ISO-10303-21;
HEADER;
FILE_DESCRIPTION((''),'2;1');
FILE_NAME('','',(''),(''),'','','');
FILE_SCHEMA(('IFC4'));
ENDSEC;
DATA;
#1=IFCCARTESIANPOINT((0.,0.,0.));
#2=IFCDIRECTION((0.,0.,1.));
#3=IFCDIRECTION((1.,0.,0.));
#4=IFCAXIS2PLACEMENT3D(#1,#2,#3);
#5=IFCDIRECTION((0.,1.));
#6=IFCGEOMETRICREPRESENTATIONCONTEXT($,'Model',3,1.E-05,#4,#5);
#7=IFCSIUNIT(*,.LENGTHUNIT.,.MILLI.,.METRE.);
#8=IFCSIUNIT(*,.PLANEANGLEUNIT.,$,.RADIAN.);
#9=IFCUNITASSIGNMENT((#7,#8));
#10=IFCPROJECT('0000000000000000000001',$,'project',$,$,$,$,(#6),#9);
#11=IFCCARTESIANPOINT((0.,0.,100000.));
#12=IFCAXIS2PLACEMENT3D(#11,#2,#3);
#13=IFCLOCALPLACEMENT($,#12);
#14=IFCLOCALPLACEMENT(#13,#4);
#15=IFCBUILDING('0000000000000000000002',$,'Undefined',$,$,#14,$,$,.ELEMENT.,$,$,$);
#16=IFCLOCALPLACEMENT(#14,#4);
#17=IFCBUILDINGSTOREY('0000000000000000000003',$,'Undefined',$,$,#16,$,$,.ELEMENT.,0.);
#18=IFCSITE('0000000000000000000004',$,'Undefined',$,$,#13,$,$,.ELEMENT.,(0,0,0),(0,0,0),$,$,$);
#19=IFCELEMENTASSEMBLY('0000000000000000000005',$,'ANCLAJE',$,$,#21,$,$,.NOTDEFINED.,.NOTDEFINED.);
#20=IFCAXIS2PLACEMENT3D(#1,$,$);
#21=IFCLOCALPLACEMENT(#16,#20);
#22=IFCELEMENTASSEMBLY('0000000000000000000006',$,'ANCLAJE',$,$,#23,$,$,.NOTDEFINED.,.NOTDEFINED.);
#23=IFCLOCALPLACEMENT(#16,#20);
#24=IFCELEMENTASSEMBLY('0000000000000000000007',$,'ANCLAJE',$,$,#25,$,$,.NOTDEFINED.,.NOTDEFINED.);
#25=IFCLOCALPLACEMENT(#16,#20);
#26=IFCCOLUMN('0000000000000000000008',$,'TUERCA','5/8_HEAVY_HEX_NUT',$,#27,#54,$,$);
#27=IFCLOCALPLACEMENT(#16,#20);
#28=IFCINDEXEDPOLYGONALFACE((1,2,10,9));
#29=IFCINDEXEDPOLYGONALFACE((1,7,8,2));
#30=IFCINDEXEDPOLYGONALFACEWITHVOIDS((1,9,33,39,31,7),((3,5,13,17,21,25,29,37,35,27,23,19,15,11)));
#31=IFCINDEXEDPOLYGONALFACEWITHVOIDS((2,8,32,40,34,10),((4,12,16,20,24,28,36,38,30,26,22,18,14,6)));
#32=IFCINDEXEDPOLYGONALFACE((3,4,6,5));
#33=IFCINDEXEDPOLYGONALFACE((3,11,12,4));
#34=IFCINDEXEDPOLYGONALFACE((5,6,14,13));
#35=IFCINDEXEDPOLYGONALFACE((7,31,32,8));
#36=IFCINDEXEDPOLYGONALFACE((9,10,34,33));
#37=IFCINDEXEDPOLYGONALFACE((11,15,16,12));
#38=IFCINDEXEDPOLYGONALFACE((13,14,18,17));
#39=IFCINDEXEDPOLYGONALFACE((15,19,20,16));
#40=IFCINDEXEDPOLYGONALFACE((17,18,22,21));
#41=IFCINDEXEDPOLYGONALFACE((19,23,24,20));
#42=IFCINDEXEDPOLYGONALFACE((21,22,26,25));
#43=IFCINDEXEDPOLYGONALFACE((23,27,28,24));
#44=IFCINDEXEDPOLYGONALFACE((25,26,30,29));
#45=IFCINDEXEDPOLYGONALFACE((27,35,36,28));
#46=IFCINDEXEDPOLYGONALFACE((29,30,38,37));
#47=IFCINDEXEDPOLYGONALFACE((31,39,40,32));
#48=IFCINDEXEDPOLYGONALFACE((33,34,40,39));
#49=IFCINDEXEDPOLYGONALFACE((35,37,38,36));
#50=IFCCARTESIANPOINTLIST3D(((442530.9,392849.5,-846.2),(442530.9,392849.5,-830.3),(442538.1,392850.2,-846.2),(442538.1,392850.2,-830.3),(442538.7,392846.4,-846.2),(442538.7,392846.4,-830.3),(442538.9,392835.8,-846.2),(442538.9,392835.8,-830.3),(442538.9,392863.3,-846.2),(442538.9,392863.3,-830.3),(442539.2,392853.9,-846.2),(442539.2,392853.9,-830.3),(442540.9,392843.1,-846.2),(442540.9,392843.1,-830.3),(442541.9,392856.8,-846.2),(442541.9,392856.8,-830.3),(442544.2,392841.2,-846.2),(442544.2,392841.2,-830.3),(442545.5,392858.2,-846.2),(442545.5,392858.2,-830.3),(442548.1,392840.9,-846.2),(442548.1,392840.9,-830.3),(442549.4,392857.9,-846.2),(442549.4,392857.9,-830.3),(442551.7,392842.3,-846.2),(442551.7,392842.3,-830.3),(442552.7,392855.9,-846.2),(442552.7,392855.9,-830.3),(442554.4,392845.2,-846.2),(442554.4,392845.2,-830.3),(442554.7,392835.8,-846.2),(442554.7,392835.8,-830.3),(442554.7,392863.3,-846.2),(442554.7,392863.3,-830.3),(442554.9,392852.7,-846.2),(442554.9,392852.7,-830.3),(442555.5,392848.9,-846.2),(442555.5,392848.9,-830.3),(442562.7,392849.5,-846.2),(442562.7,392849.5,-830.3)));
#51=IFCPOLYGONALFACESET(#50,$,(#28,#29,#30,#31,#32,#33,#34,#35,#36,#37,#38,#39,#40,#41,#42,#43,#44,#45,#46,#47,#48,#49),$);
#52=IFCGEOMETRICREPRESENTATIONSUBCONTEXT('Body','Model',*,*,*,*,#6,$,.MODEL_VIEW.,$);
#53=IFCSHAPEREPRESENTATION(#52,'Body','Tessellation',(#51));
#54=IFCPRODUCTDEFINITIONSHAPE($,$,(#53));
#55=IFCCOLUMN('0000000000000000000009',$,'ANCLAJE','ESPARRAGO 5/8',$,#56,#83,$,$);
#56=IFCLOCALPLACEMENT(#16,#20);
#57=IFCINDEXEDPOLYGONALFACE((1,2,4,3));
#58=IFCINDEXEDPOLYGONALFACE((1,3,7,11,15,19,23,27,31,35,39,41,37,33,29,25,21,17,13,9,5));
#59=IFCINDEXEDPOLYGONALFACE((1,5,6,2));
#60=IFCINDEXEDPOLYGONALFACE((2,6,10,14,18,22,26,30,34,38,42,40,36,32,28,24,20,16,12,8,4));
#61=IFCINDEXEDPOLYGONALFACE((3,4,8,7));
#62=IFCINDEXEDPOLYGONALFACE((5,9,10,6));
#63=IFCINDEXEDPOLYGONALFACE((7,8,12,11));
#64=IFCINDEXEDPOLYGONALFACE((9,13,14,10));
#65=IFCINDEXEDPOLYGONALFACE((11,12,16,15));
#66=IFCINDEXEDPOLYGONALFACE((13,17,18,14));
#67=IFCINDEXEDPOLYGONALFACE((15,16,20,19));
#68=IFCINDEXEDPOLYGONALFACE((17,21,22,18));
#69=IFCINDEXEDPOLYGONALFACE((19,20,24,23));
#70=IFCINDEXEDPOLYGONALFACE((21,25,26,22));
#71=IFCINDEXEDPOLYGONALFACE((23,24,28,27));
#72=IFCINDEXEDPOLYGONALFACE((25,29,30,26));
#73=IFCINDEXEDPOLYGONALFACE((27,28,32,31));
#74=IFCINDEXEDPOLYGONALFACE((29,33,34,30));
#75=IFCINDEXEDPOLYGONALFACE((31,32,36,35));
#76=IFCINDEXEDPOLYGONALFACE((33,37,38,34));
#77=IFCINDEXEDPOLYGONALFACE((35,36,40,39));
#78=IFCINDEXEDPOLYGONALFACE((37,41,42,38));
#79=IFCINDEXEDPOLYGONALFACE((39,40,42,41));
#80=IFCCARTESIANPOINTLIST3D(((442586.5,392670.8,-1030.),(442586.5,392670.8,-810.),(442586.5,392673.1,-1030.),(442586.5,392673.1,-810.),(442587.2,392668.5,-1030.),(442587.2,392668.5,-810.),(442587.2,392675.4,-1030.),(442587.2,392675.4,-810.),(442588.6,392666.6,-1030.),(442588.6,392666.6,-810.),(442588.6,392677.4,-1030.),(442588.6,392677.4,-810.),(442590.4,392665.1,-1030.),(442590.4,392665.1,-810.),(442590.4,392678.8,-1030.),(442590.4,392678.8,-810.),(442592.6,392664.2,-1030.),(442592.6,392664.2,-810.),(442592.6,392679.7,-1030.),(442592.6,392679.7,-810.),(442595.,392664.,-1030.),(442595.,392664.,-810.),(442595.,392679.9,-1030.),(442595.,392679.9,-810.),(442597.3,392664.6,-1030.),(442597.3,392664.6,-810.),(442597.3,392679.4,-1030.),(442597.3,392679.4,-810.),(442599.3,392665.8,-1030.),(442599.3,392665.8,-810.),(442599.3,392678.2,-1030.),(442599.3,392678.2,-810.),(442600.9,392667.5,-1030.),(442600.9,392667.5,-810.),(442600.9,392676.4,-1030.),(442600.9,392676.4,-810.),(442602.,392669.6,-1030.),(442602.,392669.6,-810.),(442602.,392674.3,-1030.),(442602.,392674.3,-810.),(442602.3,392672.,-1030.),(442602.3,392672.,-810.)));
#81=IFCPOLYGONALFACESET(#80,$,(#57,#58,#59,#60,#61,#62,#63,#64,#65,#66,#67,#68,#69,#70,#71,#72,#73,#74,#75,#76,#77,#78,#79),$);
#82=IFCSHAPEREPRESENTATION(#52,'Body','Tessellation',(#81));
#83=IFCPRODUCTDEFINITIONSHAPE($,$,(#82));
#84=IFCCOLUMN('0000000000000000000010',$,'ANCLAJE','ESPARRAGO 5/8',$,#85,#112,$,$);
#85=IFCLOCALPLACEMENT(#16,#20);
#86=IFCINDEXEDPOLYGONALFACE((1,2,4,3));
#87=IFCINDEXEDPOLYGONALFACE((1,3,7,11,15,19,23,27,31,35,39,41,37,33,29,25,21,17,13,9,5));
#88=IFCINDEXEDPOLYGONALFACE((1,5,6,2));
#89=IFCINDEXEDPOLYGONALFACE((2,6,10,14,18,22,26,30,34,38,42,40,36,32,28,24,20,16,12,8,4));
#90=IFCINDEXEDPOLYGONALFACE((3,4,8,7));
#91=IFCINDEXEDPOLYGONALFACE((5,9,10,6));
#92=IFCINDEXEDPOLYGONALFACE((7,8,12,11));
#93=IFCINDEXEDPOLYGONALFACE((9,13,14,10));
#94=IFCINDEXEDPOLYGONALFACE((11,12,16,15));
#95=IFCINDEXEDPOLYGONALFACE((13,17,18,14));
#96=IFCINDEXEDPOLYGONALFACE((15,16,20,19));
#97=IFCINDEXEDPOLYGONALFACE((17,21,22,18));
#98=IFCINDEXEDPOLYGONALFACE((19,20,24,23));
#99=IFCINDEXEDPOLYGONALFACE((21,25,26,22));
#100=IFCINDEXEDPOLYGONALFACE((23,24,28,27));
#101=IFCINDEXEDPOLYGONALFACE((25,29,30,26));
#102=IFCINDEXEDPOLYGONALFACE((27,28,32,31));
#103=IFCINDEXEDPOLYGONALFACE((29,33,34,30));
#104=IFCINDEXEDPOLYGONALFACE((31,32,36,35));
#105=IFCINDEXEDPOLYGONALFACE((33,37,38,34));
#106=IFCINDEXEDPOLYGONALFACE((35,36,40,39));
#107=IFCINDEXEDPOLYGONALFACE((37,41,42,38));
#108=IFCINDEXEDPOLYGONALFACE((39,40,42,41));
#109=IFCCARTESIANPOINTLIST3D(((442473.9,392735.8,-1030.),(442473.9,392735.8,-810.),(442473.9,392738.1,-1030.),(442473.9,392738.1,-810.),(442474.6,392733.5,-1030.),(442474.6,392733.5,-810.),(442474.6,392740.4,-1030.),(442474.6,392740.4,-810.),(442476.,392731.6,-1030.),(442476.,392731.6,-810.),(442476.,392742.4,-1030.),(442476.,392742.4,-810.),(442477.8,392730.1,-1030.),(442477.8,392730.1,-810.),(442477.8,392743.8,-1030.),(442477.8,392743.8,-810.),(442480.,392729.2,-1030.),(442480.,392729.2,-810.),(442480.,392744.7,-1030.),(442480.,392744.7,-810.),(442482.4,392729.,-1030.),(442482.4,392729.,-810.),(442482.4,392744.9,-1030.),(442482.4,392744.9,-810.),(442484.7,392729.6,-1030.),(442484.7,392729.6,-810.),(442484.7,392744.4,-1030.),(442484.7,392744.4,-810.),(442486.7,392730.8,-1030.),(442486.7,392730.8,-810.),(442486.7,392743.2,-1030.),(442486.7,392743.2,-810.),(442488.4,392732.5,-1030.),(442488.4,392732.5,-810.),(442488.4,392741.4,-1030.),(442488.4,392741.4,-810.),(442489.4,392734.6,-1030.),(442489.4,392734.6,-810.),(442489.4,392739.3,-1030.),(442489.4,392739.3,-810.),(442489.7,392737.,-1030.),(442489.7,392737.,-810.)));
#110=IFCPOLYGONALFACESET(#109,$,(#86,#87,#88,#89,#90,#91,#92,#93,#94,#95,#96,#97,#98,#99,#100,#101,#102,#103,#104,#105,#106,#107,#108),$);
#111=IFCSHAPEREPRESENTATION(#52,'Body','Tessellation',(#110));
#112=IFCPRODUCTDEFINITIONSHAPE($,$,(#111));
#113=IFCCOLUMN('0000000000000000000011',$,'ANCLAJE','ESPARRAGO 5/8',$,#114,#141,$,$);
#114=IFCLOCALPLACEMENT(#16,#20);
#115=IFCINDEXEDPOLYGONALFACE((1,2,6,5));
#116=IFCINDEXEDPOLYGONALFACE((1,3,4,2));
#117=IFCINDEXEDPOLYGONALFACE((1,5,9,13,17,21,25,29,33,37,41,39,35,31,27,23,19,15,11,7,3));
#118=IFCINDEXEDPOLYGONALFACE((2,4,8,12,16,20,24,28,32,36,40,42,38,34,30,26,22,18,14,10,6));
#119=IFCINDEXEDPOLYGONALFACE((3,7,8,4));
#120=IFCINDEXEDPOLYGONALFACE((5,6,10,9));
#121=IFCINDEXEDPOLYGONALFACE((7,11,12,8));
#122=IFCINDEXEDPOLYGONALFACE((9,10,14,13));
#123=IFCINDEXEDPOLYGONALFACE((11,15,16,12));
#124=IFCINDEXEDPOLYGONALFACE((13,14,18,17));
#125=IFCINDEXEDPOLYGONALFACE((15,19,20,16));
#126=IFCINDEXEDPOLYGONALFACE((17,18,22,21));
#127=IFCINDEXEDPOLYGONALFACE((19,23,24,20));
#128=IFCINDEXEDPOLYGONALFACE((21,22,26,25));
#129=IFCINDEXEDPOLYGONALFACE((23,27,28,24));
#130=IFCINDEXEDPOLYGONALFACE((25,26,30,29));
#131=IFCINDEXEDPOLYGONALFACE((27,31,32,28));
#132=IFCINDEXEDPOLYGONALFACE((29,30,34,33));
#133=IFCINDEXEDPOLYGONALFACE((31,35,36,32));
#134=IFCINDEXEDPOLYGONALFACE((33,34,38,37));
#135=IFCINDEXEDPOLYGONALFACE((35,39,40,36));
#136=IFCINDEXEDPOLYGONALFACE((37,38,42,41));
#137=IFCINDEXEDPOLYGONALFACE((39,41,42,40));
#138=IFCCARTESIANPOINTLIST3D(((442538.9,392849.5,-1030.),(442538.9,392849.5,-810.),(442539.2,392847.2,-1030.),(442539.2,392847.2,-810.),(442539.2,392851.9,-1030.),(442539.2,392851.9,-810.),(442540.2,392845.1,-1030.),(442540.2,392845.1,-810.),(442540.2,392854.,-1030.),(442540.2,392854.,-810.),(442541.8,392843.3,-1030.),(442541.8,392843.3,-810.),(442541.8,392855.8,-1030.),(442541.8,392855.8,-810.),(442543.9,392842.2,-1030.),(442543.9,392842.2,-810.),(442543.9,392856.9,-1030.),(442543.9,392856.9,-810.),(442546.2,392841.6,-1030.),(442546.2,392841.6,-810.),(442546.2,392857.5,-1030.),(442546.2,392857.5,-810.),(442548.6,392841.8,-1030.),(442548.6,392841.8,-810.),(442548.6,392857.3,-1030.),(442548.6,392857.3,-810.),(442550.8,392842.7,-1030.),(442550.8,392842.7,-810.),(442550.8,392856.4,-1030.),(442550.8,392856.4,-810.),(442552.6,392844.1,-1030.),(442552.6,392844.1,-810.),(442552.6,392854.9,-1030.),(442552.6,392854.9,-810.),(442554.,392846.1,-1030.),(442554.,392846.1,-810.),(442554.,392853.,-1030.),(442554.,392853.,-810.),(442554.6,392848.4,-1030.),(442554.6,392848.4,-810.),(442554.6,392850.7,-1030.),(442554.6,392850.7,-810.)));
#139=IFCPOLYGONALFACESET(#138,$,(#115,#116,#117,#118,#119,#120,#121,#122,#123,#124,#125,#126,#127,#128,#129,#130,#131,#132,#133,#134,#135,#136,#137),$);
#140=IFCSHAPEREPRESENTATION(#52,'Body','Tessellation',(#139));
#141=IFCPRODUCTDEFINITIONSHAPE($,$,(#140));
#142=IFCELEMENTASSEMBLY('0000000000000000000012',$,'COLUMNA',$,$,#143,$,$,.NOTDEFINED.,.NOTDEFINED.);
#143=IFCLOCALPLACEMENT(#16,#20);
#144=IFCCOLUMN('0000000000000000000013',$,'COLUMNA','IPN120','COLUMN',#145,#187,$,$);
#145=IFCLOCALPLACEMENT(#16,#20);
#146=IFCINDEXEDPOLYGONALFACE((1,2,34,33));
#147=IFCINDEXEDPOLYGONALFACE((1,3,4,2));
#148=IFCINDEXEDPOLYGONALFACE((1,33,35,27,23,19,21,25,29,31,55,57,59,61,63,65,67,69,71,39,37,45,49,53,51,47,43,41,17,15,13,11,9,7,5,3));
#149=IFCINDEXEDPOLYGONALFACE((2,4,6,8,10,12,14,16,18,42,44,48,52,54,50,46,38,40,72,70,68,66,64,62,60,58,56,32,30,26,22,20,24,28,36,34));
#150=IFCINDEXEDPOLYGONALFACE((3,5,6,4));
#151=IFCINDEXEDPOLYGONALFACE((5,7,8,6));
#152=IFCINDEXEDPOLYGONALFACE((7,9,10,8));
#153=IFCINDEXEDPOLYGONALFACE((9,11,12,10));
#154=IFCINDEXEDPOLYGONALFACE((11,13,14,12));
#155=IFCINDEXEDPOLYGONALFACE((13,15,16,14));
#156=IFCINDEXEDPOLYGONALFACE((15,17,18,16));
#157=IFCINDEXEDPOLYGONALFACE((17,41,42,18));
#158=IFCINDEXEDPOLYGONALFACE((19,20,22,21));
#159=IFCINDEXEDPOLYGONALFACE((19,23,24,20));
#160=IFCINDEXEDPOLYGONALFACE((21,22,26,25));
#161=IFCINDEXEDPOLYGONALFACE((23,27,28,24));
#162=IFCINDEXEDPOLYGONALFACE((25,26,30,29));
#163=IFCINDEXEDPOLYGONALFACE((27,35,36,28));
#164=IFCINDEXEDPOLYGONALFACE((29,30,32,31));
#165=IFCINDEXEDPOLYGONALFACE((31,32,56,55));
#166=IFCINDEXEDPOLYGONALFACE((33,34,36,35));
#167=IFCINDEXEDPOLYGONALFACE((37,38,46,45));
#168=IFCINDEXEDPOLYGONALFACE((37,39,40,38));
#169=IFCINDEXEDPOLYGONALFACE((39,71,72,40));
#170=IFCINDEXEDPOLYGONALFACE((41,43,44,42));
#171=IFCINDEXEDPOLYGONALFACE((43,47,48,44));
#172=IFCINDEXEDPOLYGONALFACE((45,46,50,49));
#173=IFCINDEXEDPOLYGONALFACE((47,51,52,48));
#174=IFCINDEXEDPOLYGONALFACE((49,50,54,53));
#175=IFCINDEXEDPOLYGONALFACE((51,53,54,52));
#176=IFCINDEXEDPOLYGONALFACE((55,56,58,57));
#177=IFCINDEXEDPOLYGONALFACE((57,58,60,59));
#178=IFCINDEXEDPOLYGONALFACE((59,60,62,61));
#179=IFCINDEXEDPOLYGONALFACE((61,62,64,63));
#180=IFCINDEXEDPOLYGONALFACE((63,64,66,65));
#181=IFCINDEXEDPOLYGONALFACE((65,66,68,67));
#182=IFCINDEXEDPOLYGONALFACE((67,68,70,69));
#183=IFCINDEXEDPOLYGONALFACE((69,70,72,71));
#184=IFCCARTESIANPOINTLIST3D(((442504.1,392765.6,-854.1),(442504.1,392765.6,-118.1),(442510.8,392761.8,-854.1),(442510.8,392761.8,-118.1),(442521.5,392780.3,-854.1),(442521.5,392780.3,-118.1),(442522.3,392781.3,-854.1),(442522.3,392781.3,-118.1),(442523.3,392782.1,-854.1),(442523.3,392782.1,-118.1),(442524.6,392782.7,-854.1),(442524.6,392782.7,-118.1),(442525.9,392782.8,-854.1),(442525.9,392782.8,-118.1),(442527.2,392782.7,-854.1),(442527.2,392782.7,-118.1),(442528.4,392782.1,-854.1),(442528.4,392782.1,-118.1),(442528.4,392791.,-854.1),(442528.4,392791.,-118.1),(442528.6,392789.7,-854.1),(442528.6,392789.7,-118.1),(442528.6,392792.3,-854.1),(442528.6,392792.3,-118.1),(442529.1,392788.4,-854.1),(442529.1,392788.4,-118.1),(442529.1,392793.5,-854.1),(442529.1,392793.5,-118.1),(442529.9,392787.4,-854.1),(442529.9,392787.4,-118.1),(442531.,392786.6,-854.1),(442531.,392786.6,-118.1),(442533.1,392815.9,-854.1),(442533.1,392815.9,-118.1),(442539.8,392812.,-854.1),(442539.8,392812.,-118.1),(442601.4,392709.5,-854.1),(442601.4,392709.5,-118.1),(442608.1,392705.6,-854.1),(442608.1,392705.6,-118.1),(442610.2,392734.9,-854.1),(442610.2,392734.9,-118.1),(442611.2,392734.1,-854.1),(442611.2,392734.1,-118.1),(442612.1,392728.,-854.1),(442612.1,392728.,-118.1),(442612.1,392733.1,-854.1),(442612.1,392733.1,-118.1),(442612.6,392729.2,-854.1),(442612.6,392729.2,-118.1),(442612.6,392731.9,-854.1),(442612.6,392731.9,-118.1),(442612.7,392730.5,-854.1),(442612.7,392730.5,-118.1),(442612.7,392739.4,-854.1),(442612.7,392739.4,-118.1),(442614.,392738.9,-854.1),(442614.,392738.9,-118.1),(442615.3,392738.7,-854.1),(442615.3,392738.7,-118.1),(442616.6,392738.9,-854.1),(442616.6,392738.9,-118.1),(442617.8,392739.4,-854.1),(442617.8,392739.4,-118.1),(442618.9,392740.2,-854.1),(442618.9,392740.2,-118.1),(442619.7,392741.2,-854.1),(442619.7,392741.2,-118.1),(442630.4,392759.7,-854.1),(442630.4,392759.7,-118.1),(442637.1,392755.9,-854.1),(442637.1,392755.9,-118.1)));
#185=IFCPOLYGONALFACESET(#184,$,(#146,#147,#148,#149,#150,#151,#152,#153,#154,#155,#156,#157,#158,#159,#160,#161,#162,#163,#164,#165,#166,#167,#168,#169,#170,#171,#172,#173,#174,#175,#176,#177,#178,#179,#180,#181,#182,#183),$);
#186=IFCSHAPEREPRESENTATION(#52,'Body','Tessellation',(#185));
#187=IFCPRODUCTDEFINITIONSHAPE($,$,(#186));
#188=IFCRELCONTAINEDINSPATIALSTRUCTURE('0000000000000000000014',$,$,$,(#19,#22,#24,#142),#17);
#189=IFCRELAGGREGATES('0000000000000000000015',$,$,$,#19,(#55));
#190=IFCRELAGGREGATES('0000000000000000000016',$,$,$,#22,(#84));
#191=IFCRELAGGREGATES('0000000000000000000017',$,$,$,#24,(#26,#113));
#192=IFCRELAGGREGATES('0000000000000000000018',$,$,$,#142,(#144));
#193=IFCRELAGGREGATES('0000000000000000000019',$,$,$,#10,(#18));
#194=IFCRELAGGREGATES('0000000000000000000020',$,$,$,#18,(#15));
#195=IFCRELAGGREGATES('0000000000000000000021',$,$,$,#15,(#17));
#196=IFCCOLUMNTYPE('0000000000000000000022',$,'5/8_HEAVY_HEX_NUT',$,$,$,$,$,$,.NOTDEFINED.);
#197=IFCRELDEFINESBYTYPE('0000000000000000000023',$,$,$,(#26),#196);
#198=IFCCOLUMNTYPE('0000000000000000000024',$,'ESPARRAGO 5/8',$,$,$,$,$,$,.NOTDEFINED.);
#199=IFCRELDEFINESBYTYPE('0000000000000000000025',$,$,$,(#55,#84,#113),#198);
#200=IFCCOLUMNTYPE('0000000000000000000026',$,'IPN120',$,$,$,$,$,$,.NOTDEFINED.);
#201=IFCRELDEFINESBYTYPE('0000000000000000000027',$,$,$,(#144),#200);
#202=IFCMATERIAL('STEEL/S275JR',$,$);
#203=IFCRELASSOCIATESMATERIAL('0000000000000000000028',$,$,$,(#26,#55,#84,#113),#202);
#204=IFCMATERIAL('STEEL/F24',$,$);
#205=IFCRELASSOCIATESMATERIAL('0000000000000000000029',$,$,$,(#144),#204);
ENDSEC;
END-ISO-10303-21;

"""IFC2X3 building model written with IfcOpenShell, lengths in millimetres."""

from ifc_helpers import new_model, si_unit, direction, frame, origin_with_axes, origin_2d_with_axis, place, context, subcontext, project, spatial, polyline, circle, i_section, outline, extrude, clip, halfspace, material, type_object, element, aggregate, save


model = new_model("IFC2X3")

# Units and contexts
model_context = context("Model", 3, precision=1e-05, world=origin_with_axes(), true_north=direction((0.0, 1.0)))
body_context = subcontext(model_context, "Body", "Model", "MODEL_VIEW")
ifc_project = project(units=[si_unit("LENGTHUNIT", "METRE", prefix="MILLI"), si_unit("PLANEANGLEUNIT", "RADIAN")], contexts=[model_context])

# Site, building, storey
site_placement = place(None, frame((0.0, 0.0, 100000.0), z_axis=(0.0, 0.0, 1.0), x_axis=(1.0, 0.0, 0.0)))
site = spatial("IfcSite", under=ifc_project, at=site_placement, Name="Undefined", CompositionType="ELEMENT", RefLatitude=(0, 0, 0), RefLongitude=(0, 0, 0))
building_placement = place(site_placement, origin_with_axes())
building = spatial("IfcBuilding", under=site, at=building_placement, Name="Undefined", CompositionType="ELEMENT")
storey_placement = place(building_placement, origin_with_axes())
storey = spatial("IfcBuildingStorey", under=building, at=storey_placement, Name="Undefined", CompositionType="ELEMENT", Elevation=0.0)

# Element assemblies
assembly_1_placement = place(storey_placement, origin_with_axes())
assembly_1 = element("IfcElementAssembly", 1, at=assembly_1_placement, inside=storey, Name="ANCLAJE", AssemblyPlace="NOTDEFINED", PredefinedType="NOTDEFINED")
ifc_material_1 = material(Name="STEEL/S275JR")
assembly_2_placement = place(storey_placement, origin_with_axes())
assembly_2 = element("IfcElementAssembly", 2, at=assembly_2_placement, inside=storey, Name="ANCLAJE", AssemblyPlace="NOTDEFINED", PredefinedType="NOTDEFINED")
assembly_3_placement = place(storey_placement, origin_with_axes())
assembly_3 = element("IfcElementAssembly", 3, at=assembly_3_placement, inside=storey, Name="ANCLAJE", AssemblyPlace="NOTDEFINED", PredefinedType="NOTDEFINED")

# Columns
column_type_1 = type_object("IfcColumnType", Name="5/8_HEAVY_HEX_NUT", PredefinedType="NOTDEFINED")
column_1_placement = place(assembly_3_placement, frame((442546.8, 392849.5, -830.3), z_axis=(0.0, 0.0, -1.0), x_axis=(-0.866025, 0.5, 0.0)))
column_1 = element("IfcColumn", 4, at=column_1_placement, type_object=column_type_1, material=ifc_material_1, Name="TUERCA", Description="5/8_HEAVY_HEX_NUT", context=body_context, shape_type="SweptSolid", body=[
    extrude(outline(polyline([(-7.9, -13.7), (-15.9, 0.0), (-7.9, 13.7), (7.9, 13.7), (15.9, 0.0), (7.9, -13.7), (-7.9, -13.7)]), holes=[polyline([(3.8, 7.9), (0.0, 8.7), (-3.8, 7.9), (-6.8, 5.4), (-8.5, 1.9), (-8.5, -1.9), (-6.8, -5.4), (-3.8, -7.9), (0.0, -8.7), (3.8, -7.9), (6.8, -5.4), (8.5, -1.9), (8.5, 1.9), (6.8, 5.4), (3.8, 7.9)])]), frame((0.0, 0.0, 15.9), z_axis=(0.0, 0.0, -1.0), x_axis=(0.0, 1.0, 0.0)), (0.0, 0.0, 1.0), 15.9),
])
column_type_2 = type_object("IfcColumnType", Name="ESPARRAGO 5/8", PredefinedType="NOTDEFINED")
column_2_placement = place(assembly_1_placement, frame((442594.4, 392672.0, -810.0), z_axis=(0.0, 0.0, -1.0), x_axis=(0.866025, -0.5, 0.0)))
column_2 = element("IfcColumn", 5, at=column_2_placement, type_object=column_type_2, material=ifc_material_1, Name="ANCLAJE", Description="ESPARRAGO 5/8", context=body_context, shape_type="SweptSolid", body=[
    extrude(circle(Radius=7.9, at=origin_2d_with_axis()), frame((0.0, 0.0, 220.0), z_axis=(0.0, 0.0, -1.0), x_axis=(0.0, 1.0, 0.0)), (0.0, 0.0, 1.0), 220.0),
])
aggregate(assembly_1, [column_2])
column_3_placement = place(assembly_2_placement, frame((442481.8, 392737.0, -810.0), z_axis=(0.0, 0.0, -1.0), x_axis=(0.866025, -0.5, 0.0)))
column_3 = element("IfcColumn", 6, at=column_3_placement, type_object=column_type_2, material=ifc_material_1, Name="ANCLAJE", Description="ESPARRAGO 5/8", context=body_context, shape_type="SweptSolid", body=[
    extrude(circle(Radius=7.9, at=origin_2d_with_axis()), frame((0.0, 0.0, 220.0), z_axis=(0.0, 0.0, -1.0), x_axis=(0.0, 1.0, 0.0)), (0.0, 0.0, 1.0), 220.0),
])
aggregate(assembly_2, [column_3])
column_4_placement = place(assembly_3_placement, frame((442546.8, 392849.5, -810.0), z_axis=(0.0, 0.0, -1.0), x_axis=(-0.866025, 0.5, 0.0)))
column_4 = element("IfcColumn", 7, at=column_4_placement, type_object=column_type_2, material=ifc_material_1, Name="ANCLAJE", Description="ESPARRAGO 5/8", context=body_context, shape_type="SweptSolid", body=[
    extrude(circle(Radius=7.9, at=origin_2d_with_axis()), frame((0.0, 0.0, 220.0), z_axis=(0.0, 0.0, -1.0), x_axis=(0.0, 1.0, 0.0)), (0.0, 0.0, 1.0), 220.0),
])
aggregate(assembly_3, [column_1, column_4])

# Element assembly, column
assembly_4_placement = place(storey_placement, origin_with_axes())
assembly_4 = element("IfcElementAssembly", 8, at=assembly_4_placement, inside=storey, Name="COLUMNA", AssemblyPlace="NOTDEFINED", PredefinedType="NOTDEFINED")
ifc_material_2 = material(Name="STEEL/F24")
column_type_3 = type_object("IfcColumnType", Name="IPN120", PredefinedType="NOTDEFINED")
column_5_placement = place(assembly_4_placement, frame((442570.6, 392760.8, -880.0), z_axis=(0.0, 0.0, 1.0), x_axis=(-0.866025, 0.5, 0.0)))
column_5 = element("IfcColumn", 9, at=column_5_placement, type_object=column_type_3, material=ifc_material_2, Name="COLUMNA", Description="IPN120", ObjectType="COLUMN", context=body_context, shape_type="Clipping", body=[
    clip(extrude(i_section(OverallWidth=58.0, OverallDepth=120.0, WebThickness=5.1, FlangeThickness=7.7, FilletRadius=5.1, at=origin_2d_with_axis()), frame((0.0, 0.0, 761.9), z_axis=(0.0, 0.0, -1.0), x_axis=(0.0, 1.0, 0.0)), (0.0, 0.0, 1.0), 761.9), halfspace(frame((-60.0, 0.0, 25.9), z_axis=(0.0, 0.0, 1.0), x_axis=(0.0, 1.0, 0.0)), True)),
])

aggregate(assembly_4, [column_5])

save(model, "model.ifc")
